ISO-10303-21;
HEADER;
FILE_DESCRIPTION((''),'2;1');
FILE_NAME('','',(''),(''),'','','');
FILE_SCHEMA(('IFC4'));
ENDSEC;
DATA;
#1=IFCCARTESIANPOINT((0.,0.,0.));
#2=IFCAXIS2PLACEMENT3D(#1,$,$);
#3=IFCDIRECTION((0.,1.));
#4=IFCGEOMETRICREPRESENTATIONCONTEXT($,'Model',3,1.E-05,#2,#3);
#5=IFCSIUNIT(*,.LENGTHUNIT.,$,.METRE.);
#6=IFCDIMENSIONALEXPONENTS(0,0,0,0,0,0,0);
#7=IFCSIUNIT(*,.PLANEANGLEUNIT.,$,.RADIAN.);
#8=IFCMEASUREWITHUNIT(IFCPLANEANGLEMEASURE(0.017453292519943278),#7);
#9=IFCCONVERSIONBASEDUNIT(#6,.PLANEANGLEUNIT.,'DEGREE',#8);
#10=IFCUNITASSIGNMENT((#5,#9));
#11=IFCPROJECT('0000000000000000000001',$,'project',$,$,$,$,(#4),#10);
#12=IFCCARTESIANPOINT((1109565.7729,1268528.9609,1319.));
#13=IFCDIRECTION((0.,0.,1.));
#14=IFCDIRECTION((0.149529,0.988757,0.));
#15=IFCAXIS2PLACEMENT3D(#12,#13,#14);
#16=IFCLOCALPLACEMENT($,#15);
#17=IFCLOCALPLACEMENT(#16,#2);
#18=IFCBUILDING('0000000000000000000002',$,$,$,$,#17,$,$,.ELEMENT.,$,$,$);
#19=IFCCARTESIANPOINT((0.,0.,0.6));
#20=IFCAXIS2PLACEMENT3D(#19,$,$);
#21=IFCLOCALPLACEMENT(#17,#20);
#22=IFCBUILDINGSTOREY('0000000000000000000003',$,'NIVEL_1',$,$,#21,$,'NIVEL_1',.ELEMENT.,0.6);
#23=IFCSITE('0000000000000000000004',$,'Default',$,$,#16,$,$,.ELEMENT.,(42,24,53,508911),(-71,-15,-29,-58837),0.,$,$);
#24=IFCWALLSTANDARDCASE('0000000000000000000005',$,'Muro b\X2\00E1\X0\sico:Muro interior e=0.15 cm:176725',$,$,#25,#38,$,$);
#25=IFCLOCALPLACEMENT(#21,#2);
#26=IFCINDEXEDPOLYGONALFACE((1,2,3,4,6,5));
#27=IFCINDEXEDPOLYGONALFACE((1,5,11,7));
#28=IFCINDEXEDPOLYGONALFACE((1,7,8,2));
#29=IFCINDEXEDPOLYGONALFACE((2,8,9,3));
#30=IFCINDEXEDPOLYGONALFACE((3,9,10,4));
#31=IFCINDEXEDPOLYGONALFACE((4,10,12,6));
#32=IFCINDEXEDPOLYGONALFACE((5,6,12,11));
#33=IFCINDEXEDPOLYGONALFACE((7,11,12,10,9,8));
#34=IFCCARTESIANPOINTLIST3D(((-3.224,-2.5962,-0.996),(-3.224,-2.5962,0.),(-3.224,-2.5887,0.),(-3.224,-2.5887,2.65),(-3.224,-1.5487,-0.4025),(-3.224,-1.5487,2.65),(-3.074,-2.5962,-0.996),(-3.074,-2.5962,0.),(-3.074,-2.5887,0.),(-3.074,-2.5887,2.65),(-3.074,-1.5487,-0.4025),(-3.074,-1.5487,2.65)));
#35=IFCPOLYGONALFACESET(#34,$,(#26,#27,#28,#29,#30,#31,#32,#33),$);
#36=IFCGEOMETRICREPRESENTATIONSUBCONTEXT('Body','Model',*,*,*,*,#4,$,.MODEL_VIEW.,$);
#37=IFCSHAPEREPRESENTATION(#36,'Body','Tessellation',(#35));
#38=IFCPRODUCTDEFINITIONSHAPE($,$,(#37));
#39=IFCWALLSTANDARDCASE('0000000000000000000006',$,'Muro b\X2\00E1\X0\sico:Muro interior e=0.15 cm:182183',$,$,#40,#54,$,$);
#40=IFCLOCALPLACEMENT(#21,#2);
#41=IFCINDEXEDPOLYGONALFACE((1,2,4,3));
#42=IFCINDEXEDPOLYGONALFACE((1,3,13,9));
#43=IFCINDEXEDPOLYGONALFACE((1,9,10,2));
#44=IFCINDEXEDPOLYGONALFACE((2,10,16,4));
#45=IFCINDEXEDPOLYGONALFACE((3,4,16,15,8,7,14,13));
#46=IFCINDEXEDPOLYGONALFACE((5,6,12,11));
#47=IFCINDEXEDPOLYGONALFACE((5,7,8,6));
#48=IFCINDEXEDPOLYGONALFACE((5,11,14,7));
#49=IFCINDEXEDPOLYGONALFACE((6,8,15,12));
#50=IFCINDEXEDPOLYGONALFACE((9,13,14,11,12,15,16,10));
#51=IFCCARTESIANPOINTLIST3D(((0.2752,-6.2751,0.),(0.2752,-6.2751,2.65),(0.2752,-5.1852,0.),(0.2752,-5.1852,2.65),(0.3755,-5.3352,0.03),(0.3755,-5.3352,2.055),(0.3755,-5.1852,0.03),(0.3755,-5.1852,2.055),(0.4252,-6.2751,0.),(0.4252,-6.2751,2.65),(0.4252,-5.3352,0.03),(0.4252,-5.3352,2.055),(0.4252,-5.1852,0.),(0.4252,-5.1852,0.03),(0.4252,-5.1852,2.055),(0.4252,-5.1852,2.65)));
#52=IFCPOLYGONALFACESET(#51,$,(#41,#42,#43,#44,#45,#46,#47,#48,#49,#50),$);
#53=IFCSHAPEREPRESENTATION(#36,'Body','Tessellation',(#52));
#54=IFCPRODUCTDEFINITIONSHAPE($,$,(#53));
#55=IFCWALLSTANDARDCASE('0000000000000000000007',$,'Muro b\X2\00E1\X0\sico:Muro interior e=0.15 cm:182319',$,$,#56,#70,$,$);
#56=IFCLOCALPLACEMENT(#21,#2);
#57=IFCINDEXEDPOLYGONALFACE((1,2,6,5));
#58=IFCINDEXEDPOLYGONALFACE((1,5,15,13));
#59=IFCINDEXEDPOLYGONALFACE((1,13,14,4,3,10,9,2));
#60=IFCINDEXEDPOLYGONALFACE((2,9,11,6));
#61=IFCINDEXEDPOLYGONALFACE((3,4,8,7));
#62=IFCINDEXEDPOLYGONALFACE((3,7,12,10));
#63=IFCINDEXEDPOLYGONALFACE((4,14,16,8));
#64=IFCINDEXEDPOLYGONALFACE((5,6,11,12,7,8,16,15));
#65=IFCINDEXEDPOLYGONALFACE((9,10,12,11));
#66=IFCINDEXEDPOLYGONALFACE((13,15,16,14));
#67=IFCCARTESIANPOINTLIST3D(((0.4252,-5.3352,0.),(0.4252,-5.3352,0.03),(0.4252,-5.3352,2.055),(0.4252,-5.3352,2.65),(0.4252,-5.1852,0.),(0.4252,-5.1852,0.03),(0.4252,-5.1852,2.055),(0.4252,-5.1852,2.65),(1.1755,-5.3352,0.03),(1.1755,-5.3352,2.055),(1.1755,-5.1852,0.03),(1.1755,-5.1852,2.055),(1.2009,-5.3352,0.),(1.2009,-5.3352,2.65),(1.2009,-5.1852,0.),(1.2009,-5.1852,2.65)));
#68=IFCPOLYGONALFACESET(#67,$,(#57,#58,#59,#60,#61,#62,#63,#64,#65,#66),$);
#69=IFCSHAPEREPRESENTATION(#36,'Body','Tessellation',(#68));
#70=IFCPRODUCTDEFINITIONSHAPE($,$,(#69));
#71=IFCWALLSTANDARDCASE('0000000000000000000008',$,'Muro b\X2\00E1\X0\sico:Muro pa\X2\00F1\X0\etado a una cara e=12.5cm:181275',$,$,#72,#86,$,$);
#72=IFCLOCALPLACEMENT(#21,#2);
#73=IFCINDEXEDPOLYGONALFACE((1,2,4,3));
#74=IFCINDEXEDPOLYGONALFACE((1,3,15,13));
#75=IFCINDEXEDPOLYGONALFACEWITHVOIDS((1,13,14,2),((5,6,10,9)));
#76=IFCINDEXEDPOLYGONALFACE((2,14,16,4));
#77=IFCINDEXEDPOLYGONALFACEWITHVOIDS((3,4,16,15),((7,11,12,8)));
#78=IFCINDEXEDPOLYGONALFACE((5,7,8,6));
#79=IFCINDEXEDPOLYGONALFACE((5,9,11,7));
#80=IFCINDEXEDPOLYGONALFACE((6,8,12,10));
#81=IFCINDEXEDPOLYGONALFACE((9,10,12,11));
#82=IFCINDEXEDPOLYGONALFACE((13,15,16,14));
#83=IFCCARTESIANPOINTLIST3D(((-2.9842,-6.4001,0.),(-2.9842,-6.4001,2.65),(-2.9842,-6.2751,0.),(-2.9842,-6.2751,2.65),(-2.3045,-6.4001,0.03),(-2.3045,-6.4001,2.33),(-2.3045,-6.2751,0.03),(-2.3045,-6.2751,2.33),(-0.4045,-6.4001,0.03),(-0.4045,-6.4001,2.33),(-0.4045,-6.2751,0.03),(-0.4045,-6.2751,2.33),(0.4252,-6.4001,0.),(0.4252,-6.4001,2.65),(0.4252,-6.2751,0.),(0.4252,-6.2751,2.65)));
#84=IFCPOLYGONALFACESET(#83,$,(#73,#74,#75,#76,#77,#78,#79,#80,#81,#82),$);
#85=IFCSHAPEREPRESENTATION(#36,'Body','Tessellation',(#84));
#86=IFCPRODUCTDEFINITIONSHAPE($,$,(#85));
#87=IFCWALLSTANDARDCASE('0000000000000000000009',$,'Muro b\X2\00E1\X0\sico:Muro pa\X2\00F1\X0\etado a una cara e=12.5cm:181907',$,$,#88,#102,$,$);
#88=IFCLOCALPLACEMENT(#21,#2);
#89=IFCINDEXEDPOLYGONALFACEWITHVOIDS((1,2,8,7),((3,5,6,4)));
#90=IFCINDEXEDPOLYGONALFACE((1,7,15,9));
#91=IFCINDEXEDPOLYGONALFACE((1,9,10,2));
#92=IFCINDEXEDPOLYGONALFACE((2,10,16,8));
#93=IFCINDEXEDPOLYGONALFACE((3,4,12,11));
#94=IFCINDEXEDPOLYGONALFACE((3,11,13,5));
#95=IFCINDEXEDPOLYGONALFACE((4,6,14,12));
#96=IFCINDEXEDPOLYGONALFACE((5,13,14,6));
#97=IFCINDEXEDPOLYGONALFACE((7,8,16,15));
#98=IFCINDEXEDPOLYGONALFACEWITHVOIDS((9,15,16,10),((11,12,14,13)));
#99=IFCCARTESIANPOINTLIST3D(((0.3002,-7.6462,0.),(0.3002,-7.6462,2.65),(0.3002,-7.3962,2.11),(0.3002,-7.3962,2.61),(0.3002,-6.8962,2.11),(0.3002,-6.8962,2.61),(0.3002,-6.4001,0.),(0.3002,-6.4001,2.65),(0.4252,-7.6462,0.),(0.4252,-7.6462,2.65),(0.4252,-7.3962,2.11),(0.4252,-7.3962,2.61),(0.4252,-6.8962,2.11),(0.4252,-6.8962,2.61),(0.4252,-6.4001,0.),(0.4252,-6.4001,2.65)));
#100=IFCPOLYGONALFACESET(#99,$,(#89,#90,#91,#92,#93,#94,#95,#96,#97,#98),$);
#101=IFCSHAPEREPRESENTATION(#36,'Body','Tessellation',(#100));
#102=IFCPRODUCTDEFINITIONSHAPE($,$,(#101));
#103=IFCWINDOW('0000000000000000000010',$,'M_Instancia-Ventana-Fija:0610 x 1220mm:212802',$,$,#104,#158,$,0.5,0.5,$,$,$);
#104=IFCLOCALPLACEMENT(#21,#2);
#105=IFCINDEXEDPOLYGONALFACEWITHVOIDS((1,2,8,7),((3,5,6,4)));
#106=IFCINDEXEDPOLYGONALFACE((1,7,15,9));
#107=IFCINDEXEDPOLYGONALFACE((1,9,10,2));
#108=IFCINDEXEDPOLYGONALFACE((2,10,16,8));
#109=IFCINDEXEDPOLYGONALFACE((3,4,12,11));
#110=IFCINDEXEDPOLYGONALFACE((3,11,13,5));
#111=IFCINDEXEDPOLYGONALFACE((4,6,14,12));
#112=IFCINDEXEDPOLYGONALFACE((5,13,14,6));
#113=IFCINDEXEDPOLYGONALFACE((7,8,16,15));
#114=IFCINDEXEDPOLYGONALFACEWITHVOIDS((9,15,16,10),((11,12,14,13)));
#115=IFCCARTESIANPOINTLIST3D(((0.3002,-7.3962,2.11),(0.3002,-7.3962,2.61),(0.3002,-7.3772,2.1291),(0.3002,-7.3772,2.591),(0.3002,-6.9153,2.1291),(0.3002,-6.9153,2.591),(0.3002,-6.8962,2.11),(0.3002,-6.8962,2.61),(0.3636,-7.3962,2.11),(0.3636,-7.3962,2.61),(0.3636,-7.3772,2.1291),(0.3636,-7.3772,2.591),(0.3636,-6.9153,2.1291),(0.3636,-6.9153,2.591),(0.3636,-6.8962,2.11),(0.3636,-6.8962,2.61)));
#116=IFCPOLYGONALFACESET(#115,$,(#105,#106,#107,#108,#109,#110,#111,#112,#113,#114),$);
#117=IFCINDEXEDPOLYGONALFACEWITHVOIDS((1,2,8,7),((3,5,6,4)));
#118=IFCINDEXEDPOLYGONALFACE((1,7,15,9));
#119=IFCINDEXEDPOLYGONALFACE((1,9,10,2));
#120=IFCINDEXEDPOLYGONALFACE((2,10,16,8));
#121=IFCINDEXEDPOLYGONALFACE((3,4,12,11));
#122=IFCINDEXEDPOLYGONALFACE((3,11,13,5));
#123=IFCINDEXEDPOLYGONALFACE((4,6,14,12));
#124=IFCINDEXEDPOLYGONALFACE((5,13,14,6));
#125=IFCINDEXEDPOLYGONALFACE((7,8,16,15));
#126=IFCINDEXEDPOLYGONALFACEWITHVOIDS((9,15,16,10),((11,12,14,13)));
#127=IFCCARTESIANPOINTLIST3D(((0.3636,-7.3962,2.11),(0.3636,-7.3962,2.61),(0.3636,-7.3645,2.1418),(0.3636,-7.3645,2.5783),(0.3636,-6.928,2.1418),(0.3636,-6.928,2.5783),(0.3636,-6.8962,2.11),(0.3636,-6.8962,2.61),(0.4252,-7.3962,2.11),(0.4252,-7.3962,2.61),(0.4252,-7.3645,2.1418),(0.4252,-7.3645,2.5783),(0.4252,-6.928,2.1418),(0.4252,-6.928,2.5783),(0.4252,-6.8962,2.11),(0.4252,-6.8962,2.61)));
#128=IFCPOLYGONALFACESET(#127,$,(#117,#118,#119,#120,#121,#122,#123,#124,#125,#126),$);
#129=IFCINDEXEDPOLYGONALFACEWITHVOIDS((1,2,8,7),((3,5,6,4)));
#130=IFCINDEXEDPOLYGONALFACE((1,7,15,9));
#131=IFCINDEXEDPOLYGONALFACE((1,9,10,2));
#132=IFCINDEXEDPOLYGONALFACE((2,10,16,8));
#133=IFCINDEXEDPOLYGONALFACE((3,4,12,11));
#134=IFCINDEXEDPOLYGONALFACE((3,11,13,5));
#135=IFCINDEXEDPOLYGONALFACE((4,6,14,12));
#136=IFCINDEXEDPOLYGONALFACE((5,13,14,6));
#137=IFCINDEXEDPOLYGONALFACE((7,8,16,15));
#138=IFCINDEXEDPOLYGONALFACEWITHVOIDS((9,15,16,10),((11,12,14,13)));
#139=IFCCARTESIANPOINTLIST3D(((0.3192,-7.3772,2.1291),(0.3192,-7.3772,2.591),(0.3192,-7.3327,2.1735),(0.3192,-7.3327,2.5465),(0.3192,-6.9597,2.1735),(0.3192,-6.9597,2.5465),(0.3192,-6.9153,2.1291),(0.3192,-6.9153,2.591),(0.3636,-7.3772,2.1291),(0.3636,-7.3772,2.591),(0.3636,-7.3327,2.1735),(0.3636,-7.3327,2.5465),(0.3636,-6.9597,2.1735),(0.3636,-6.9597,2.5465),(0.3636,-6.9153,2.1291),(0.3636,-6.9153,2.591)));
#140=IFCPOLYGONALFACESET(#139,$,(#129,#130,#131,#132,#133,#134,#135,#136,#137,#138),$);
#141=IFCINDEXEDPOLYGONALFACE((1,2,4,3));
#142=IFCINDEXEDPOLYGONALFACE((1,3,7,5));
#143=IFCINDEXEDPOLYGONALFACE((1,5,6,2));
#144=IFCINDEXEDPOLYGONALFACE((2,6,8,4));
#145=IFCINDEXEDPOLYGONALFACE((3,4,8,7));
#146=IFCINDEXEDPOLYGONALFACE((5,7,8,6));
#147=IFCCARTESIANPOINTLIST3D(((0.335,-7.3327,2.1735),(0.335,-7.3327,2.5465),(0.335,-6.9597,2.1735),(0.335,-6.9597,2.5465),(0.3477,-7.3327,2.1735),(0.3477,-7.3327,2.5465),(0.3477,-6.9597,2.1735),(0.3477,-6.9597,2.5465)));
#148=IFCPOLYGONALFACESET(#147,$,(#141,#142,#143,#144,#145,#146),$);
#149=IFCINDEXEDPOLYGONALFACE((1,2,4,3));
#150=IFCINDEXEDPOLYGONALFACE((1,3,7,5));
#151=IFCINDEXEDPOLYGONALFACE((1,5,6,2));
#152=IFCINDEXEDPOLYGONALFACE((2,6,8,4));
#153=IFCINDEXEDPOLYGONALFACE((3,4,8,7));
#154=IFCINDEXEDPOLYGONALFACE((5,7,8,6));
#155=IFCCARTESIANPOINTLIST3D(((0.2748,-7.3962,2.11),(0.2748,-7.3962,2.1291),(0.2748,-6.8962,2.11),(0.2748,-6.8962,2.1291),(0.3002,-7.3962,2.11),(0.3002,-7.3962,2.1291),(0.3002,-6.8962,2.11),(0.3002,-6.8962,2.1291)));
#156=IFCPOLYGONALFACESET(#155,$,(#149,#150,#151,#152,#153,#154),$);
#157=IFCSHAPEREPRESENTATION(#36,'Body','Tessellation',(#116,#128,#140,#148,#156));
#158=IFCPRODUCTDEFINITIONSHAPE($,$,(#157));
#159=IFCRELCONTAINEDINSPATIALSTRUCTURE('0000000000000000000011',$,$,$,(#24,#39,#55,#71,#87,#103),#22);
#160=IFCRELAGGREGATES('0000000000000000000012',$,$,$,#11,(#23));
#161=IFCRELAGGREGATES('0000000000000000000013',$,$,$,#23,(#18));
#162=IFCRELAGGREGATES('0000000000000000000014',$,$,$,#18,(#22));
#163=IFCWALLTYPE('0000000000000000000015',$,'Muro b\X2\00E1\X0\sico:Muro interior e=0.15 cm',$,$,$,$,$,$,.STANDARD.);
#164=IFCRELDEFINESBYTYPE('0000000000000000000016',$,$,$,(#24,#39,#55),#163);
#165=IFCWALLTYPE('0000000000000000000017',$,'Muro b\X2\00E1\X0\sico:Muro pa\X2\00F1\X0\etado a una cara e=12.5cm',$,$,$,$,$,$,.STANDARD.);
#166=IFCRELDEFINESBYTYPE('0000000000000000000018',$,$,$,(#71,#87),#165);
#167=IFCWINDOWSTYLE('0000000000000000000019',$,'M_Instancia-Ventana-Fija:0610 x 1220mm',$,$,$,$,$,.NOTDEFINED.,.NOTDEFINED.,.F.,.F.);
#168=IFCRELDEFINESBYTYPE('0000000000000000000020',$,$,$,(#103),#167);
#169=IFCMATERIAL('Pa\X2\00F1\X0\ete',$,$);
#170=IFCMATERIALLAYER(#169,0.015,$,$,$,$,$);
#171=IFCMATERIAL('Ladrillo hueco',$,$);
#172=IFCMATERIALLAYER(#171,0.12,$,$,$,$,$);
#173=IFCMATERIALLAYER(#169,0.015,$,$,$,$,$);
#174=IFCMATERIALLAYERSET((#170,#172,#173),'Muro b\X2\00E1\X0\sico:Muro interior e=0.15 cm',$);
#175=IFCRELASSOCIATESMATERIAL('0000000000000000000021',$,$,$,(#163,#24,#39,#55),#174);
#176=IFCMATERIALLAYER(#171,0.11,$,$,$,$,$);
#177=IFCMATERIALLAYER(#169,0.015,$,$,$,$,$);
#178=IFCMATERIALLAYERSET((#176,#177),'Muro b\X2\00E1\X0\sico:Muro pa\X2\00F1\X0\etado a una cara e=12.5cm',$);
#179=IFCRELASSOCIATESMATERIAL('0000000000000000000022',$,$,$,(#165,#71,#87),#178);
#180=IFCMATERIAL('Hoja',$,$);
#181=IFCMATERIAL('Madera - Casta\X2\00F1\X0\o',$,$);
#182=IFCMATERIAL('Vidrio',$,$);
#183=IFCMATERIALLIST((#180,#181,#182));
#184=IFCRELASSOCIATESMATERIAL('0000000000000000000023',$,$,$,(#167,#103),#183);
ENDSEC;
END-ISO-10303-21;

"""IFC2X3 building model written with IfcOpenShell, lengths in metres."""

from ifc_helpers import new_model, entity, si_unit, converted_unit, direction, frame, frame_2d, origin, origin_2d_with_axis, place, context, subcontext, project, spatial, polyline, rectangle, outline, extrude, clip, halfspace, source, transform, mapped, material, material_list, layer, layer_set, layer_usage, type_object, type_shapes, element, fill, save


model = new_model("IFC2X3")

# Units and contexts
model_context = context("Model", 3, precision=1e-05, world=origin(), true_north=direction((0.0, 1.0)))
body_context = subcontext(model_context, "Body", "Model", "MODEL_VIEW")
ifc_project = project(units=[si_unit("LENGTHUNIT", "METRE"), converted_unit("PLANEANGLEUNIT", "DEGREE", entity("IfcPlaneAngleMeasure", 0.017453292519943278), si_unit("PLANEANGLEUNIT", "RADIAN"), dimensions=[0, 0, 0, 0, 0, 0, 0])], contexts=[model_context])

# Site, building, storey
site_placement = place(None, frame((1109565.7729, 1268528.9609, 1319.0), z_axis=(0.0, 0.0, 1.0), x_axis=(0.149529, 0.988757, 0.0)))
site = spatial("IfcSite", under=ifc_project, at=site_placement, Name="Default", CompositionType="ELEMENT", RefLatitude=(42, 24, 53, 508911), RefLongitude=(-71, -15, -29, -58837), RefElevation=0.0)
building_placement = place(site_placement, origin())
building = spatial("IfcBuilding", under=site, at=building_placement, CompositionType="ELEMENT")
storey_placement = place(building_placement, frame((0.0, 0.0, 0.6)))
storey = spatial("IfcBuildingStorey", under=building, at=storey_placement, Name="NIVEL_1", LongName="NIVEL_1", CompositionType="ELEMENT", Elevation=0.6)

# Walls, openings
ifc_material_1 = material(Name="Pañete")
ifc_layer_1 = layer(ifc_material_1, 0.015)
ifc_material_2 = material(Name="Ladrillo hueco")
ifc_layer_2 = layer(ifc_material_2, 0.12)
ifc_layer_3 = layer(ifc_material_1, 0.015)
ifc_layer_set_1 = layer_set([ifc_layer_1, ifc_layer_2, ifc_layer_3], Name="Muro básico:Muro interior e=0.15 cm")
ifc_layer_usage_1 = layer_usage(ifc_layer_set_1, "AXIS2", "POSITIVE", -0.075)
wall_type_1 = type_object("IfcWallType", Name="Muro básico:Muro interior e=0.15 cm", PredefinedType="STANDARD", material=ifc_layer_set_1)
wall_1_placement = place(storey_placement, frame((-3.149, -2.5962, -0.996), z_axis=(0.0, 0.0, 1.0), x_axis=(0.0, 1.0, 0.0)))
wall_1 = element("IfcWallStandardCase", 1, at=wall_1_placement, inside=storey, type_object=wall_type_1, material=ifc_layer_usage_1, Name="Muro básico:Muro interior e=0.15 cm:176725", context=body_context, shape_type="Clipping", body=[
    clip(extrude(rectangle(XDim=1.0475, YDim=0.15, at=frame_2d((0.5237, 0.0), x_axis=(-1.0, 0.0))), origin(), (0.0, 0.0, 1.0), 3.646), halfspace(frame((1.0475, -0.075, 0.5936), z_axis=(0.493013, 0.0, -0.870022), x_axis=(0.0, 1.0, 0.0)), False)),
])
opening_1_placement = place(wall_1_placement, origin())
element("IfcOpeningElement", 2, at=opening_1_placement, cuts=wall_1, ObjectType="Opening", context=body_context, shape_type="SweptSolid", body=[
    extrude(rectangle(XDim=2.65, YDim=0.0075, at=frame_2d((0.0, 0.0), x_axis=(0.0, 1.0))), frame((0.0037, 0.075, 2.321), z_axis=(0.0, -1.0, 0.0), x_axis=(1.0, 0.0, 0.0)), (0.0, 0.0, 1.0), 0.15),
])
ifc_layer_usage_2 = layer_usage(ifc_layer_set_1, "AXIS2", "NEGATIVE", 0.075)
wall_2_placement = place(storey_placement, frame((0.3502, -6.2751, 0.0), z_axis=(0.0, 0.0, 1.0), x_axis=(0.0, 1.0, 0.0)))
wall_2 = element("IfcWallStandardCase", 3, at=wall_2_placement, inside=storey, type_object=wall_type_1, material=ifc_layer_usage_2, Name="Muro básico:Muro interior e=0.15 cm:182183", context=body_context, shape_type="SweptSolid", body=[
    extrude(rectangle(XDim=1.0899, YDim=0.15, at=frame_2d((0.545, 0.0), x_axis=(-1.0, 0.0))), origin(), (0.0, 0.0, 1.0), 2.65),
])
opening_2_placement = place(wall_2_placement, frame((6.2751, 0.3502, 0.03)))
element("IfcOpeningElement", 4, at=opening_2_placement, cuts=wall_2, ObjectType="Opening", context=body_context, shape_type="SweptSolid", body=[
    extrude(rectangle(XDim=2.025, YDim=0.15, at=frame_2d((0.0, 0.0), x_axis=(0.0, 1.0))), frame((-5.2602, -1.1755, 1.0125), z_axis=(0.0, 1.0, 0.0), x_axis=(-1.0, 0.0, 0.0)), (0.0, 0.0, 1.0), 0.8),
])
ifc_layer_usage_3 = layer_usage(ifc_layer_set_1, "AXIS2", "NEGATIVE", 0.075)
wall_3_placement = place(storey_placement, frame((0.4252, -5.2602, 0.0)))
wall_3 = element("IfcWallStandardCase", 5, at=wall_3_placement, inside=storey, type_object=wall_type_1, material=ifc_layer_usage_3, Name="Muro básico:Muro interior e=0.15 cm:182319", context=body_context, shape_type="SweptSolid", body=[
    extrude(rectangle(XDim=0.7757, YDim=0.15, at=frame_2d((0.3879, 0.0), x_axis=(-1.0, 0.0))), origin(), (0.0, 0.0, 1.0), 2.65),
])
opening_3_placement = place(wall_3_placement, frame((0.7504, 0.075, 0.03)))
element("IfcOpeningElement", 6, at=opening_3_placement, cuts=wall_3, ObjectType="Opening", context=body_context, shape_type="SweptSolid", body=[
    extrude(rectangle(XDim=2.025, YDim=0.8, at=frame_2d((1.0125, 0.4), x_axis=(1.0, 0.0))), frame((0.0, 0.0, 0.0), z_axis=(0.0, -1.0, 0.0), x_axis=(0.0, 0.0, 1.0)), (0.0, 0.0, 1.0), 0.15),
])
ifc_layer_4 = layer(ifc_material_2, 0.11)
ifc_layer_5 = layer(ifc_material_1, 0.015)
ifc_layer_set_2 = layer_set([ifc_layer_4, ifc_layer_5], Name="Muro básico:Muro pañetado a una cara e=12.5cm")
ifc_layer_usage_4 = layer_usage(ifc_layer_set_2, "AXIS2", "POSITIVE", -0.0625)
wall_type_2 = type_object("IfcWallType", Name="Muro básico:Muro pañetado a una cara e=12.5cm", PredefinedType="STANDARD", material=ifc_layer_set_2)
wall_4_placement = place(storey_placement, frame((-2.9842, -6.3376, 0.0)))
wall_4 = element("IfcWallStandardCase", 7, at=wall_4_placement, inside=storey, type_object=wall_type_2, material=ifc_layer_usage_4, Name="Muro básico:Muro pañetado a una cara e=12.5cm:181275", context=body_context, shape_type="SweptSolid", body=[
    extrude(rectangle(XDim=3.4094, YDim=0.125, at=frame_2d((1.7047, 0.0), x_axis=(-1.0, 0.0))), origin(), (0.0, 0.0, 1.0), 2.65),
])
opening_4_placement = place(wall_4_placement, frame((0.6797, -0.0625, 0.03)))
element("IfcOpeningElement", 8, at=opening_4_placement, cuts=wall_4, ObjectType="Opening", context=body_context, shape_type="SweptSolid", body=[
    extrude(rectangle(XDim=2.3, YDim=1.9, at=frame_2d((1.15, 0.95), x_axis=(1.0, 0.0))), frame((0.0, 0.0, 0.0), z_axis=(0.0, 1.0, 0.0), x_axis=(0.0, 0.0, 1.0)), (0.0, 0.0, 1.0), 0.125),
])

# Wall, opening, window
ifc_layer_usage_5 = layer_usage(ifc_layer_set_2, "AXIS2", "POSITIVE", -0.0625)
wall_5_placement = place(storey_placement, frame((0.3627, -6.4001, 0.0), z_axis=(0.0, 0.0, 1.0), x_axis=(0.0, -1.0, 0.0)))
wall_5 = element("IfcWallStandardCase", 9, at=wall_5_placement, inside=storey, type_object=wall_type_2, material=ifc_layer_usage_5, Name="Muro básico:Muro pañetado a una cara e=12.5cm:181907", context=body_context, shape_type="SweptSolid", body=[
    extrude(rectangle(XDim=1.2461, YDim=0.125, at=frame_2d((0.623, 0.0), x_axis=(-1.0, 0.0))), origin(), (0.0, 0.0, 1.0), 2.65),
])
opening_5_placement = place(wall_5_placement, frame((0.9961, 0.0625, 2.11)))
opening_5 = element("IfcOpeningElement", 10, at=opening_5_placement, cuts=wall_5, ObjectType="Opening", context=body_context, shape_type="SweptSolid", body=[
    extrude(rectangle(XDim=0.5, YDim=0.5, at=frame_2d((0.25, 0.25), x_axis=(-1.0, 0.0))), frame((0.0, 0.0, 0.0), z_axis=(0.0, -1.0, 0.0), x_axis=(0.0, 0.0, 1.0)), (0.0, 0.0, 1.0), 0.125),
])
ifc_material_3 = material(Name="Hoja")
ifc_material_4 = material(Name="Madera - Castaño")
ifc_material_5 = material(Name="Vidrio")
ifc_material_list = material_list([ifc_material_3, ifc_material_4, ifc_material_5])
window_style = type_object("IfcWindowStyle", Name="M_Instancia-Ventana-Fija:0610 x 1220mm", ConstructionType="NOTDEFINED", OperationType="NOTDEFINED", ParameterTakesPrecedence=False, Sizeable=False, material=ifc_material_list)
shared_shape = source(origin(), body_context, "Body", "SweptSolid", [
    extrude(outline(polyline([(-0.25, -0.25), (0.25, -0.25), (0.25, 0.25), (-0.25, 0.25), (-0.25, -0.25)]), holes=[polyline([(-0.2309, -0.2309), (-0.2309, 0.231), (0.231, 0.231), (0.231, -0.2309), (-0.2309, -0.2309)])]), frame((0.25, 0.0616, 0.25), z_axis=(0.0, 1.0, 0.0), x_axis=(0.0, 0.0, -1.0)), (0.0, 0.0, 1.0), 0.0635),
    extrude(outline(polyline([(-0.25, -0.25), (0.25, -0.25), (0.25, 0.25), (-0.25, 0.25), (-0.25, -0.25)]), holes=[polyline([(-0.2183, -0.2182), (-0.2183, 0.2183), (0.2182, 0.2183), (0.2182, -0.2182), (-0.2183, -0.2182)])]), frame((0.25, 0.0, 0.25), z_axis=(0.0, 1.0, 0.0), x_axis=(1.0, 0.0, 0.0)), (0.0, 0.0, 1.0), 0.0616),
    extrude(outline(polyline([(-0.2309, -0.231), (0.2309, -0.231), (0.2309, 0.231), (-0.2309, 0.231), (-0.2309, -0.231)]), holes=[polyline([(-0.1865, -0.1865), (-0.1865, 0.1865), (0.1865, 0.1865), (0.1865, -0.1865), (-0.1865, -0.1865)])]), frame((0.25, 0.0616, 0.25), z_axis=(0.0, 1.0, 0.0), x_axis=(1.0, 0.0, 0.0)), (0.0, 0.0, 1.0), 0.0444),
    extrude(rectangle(XDim=0.0127, YDim=0.373, at=origin_2d_with_axis()), frame((0.25, 0.0838, 0.0635), z_axis=(0.0, 0.0, 1.0), x_axis=(0.0, 1.0, 0.0)), (0.0, 0.0, 1.0), 0.373),
    extrude(rectangle(XDim=0.0254, YDim=0.5, at=origin_2d_with_axis()), frame((0.25, 0.1377, 0.0), z_axis=(0.0, 0.0, 1.0), x_axis=(0.0, -1.0, 0.0)), (0.0, 0.0, 1.0), 0.019),
])
type_shapes(window_style, [shared_shape])
window_placement = place(opening_5_placement, frame((0.0, 0.0, 0.0), z_axis=(0.0, 0.0, 1.0), x_axis=(-1.0, 0.0, 0.0)))
window = element("IfcWindow", 11, at=window_placement, inside=storey, type_object=window_style, material=ifc_material_list, Name="M_Instancia-Ventana-Fija:0610 x 1220mm:212802", OverallHeight=0.5, OverallWidth=0.5, context=body_context, shape_type="MappedRepresentation", body=[
    mapped(shared_shape, transform((0.0, 0.0, 0.0), scale=1.0)),
])
fill(opening_5, window)

save(model, "model.ifc")
